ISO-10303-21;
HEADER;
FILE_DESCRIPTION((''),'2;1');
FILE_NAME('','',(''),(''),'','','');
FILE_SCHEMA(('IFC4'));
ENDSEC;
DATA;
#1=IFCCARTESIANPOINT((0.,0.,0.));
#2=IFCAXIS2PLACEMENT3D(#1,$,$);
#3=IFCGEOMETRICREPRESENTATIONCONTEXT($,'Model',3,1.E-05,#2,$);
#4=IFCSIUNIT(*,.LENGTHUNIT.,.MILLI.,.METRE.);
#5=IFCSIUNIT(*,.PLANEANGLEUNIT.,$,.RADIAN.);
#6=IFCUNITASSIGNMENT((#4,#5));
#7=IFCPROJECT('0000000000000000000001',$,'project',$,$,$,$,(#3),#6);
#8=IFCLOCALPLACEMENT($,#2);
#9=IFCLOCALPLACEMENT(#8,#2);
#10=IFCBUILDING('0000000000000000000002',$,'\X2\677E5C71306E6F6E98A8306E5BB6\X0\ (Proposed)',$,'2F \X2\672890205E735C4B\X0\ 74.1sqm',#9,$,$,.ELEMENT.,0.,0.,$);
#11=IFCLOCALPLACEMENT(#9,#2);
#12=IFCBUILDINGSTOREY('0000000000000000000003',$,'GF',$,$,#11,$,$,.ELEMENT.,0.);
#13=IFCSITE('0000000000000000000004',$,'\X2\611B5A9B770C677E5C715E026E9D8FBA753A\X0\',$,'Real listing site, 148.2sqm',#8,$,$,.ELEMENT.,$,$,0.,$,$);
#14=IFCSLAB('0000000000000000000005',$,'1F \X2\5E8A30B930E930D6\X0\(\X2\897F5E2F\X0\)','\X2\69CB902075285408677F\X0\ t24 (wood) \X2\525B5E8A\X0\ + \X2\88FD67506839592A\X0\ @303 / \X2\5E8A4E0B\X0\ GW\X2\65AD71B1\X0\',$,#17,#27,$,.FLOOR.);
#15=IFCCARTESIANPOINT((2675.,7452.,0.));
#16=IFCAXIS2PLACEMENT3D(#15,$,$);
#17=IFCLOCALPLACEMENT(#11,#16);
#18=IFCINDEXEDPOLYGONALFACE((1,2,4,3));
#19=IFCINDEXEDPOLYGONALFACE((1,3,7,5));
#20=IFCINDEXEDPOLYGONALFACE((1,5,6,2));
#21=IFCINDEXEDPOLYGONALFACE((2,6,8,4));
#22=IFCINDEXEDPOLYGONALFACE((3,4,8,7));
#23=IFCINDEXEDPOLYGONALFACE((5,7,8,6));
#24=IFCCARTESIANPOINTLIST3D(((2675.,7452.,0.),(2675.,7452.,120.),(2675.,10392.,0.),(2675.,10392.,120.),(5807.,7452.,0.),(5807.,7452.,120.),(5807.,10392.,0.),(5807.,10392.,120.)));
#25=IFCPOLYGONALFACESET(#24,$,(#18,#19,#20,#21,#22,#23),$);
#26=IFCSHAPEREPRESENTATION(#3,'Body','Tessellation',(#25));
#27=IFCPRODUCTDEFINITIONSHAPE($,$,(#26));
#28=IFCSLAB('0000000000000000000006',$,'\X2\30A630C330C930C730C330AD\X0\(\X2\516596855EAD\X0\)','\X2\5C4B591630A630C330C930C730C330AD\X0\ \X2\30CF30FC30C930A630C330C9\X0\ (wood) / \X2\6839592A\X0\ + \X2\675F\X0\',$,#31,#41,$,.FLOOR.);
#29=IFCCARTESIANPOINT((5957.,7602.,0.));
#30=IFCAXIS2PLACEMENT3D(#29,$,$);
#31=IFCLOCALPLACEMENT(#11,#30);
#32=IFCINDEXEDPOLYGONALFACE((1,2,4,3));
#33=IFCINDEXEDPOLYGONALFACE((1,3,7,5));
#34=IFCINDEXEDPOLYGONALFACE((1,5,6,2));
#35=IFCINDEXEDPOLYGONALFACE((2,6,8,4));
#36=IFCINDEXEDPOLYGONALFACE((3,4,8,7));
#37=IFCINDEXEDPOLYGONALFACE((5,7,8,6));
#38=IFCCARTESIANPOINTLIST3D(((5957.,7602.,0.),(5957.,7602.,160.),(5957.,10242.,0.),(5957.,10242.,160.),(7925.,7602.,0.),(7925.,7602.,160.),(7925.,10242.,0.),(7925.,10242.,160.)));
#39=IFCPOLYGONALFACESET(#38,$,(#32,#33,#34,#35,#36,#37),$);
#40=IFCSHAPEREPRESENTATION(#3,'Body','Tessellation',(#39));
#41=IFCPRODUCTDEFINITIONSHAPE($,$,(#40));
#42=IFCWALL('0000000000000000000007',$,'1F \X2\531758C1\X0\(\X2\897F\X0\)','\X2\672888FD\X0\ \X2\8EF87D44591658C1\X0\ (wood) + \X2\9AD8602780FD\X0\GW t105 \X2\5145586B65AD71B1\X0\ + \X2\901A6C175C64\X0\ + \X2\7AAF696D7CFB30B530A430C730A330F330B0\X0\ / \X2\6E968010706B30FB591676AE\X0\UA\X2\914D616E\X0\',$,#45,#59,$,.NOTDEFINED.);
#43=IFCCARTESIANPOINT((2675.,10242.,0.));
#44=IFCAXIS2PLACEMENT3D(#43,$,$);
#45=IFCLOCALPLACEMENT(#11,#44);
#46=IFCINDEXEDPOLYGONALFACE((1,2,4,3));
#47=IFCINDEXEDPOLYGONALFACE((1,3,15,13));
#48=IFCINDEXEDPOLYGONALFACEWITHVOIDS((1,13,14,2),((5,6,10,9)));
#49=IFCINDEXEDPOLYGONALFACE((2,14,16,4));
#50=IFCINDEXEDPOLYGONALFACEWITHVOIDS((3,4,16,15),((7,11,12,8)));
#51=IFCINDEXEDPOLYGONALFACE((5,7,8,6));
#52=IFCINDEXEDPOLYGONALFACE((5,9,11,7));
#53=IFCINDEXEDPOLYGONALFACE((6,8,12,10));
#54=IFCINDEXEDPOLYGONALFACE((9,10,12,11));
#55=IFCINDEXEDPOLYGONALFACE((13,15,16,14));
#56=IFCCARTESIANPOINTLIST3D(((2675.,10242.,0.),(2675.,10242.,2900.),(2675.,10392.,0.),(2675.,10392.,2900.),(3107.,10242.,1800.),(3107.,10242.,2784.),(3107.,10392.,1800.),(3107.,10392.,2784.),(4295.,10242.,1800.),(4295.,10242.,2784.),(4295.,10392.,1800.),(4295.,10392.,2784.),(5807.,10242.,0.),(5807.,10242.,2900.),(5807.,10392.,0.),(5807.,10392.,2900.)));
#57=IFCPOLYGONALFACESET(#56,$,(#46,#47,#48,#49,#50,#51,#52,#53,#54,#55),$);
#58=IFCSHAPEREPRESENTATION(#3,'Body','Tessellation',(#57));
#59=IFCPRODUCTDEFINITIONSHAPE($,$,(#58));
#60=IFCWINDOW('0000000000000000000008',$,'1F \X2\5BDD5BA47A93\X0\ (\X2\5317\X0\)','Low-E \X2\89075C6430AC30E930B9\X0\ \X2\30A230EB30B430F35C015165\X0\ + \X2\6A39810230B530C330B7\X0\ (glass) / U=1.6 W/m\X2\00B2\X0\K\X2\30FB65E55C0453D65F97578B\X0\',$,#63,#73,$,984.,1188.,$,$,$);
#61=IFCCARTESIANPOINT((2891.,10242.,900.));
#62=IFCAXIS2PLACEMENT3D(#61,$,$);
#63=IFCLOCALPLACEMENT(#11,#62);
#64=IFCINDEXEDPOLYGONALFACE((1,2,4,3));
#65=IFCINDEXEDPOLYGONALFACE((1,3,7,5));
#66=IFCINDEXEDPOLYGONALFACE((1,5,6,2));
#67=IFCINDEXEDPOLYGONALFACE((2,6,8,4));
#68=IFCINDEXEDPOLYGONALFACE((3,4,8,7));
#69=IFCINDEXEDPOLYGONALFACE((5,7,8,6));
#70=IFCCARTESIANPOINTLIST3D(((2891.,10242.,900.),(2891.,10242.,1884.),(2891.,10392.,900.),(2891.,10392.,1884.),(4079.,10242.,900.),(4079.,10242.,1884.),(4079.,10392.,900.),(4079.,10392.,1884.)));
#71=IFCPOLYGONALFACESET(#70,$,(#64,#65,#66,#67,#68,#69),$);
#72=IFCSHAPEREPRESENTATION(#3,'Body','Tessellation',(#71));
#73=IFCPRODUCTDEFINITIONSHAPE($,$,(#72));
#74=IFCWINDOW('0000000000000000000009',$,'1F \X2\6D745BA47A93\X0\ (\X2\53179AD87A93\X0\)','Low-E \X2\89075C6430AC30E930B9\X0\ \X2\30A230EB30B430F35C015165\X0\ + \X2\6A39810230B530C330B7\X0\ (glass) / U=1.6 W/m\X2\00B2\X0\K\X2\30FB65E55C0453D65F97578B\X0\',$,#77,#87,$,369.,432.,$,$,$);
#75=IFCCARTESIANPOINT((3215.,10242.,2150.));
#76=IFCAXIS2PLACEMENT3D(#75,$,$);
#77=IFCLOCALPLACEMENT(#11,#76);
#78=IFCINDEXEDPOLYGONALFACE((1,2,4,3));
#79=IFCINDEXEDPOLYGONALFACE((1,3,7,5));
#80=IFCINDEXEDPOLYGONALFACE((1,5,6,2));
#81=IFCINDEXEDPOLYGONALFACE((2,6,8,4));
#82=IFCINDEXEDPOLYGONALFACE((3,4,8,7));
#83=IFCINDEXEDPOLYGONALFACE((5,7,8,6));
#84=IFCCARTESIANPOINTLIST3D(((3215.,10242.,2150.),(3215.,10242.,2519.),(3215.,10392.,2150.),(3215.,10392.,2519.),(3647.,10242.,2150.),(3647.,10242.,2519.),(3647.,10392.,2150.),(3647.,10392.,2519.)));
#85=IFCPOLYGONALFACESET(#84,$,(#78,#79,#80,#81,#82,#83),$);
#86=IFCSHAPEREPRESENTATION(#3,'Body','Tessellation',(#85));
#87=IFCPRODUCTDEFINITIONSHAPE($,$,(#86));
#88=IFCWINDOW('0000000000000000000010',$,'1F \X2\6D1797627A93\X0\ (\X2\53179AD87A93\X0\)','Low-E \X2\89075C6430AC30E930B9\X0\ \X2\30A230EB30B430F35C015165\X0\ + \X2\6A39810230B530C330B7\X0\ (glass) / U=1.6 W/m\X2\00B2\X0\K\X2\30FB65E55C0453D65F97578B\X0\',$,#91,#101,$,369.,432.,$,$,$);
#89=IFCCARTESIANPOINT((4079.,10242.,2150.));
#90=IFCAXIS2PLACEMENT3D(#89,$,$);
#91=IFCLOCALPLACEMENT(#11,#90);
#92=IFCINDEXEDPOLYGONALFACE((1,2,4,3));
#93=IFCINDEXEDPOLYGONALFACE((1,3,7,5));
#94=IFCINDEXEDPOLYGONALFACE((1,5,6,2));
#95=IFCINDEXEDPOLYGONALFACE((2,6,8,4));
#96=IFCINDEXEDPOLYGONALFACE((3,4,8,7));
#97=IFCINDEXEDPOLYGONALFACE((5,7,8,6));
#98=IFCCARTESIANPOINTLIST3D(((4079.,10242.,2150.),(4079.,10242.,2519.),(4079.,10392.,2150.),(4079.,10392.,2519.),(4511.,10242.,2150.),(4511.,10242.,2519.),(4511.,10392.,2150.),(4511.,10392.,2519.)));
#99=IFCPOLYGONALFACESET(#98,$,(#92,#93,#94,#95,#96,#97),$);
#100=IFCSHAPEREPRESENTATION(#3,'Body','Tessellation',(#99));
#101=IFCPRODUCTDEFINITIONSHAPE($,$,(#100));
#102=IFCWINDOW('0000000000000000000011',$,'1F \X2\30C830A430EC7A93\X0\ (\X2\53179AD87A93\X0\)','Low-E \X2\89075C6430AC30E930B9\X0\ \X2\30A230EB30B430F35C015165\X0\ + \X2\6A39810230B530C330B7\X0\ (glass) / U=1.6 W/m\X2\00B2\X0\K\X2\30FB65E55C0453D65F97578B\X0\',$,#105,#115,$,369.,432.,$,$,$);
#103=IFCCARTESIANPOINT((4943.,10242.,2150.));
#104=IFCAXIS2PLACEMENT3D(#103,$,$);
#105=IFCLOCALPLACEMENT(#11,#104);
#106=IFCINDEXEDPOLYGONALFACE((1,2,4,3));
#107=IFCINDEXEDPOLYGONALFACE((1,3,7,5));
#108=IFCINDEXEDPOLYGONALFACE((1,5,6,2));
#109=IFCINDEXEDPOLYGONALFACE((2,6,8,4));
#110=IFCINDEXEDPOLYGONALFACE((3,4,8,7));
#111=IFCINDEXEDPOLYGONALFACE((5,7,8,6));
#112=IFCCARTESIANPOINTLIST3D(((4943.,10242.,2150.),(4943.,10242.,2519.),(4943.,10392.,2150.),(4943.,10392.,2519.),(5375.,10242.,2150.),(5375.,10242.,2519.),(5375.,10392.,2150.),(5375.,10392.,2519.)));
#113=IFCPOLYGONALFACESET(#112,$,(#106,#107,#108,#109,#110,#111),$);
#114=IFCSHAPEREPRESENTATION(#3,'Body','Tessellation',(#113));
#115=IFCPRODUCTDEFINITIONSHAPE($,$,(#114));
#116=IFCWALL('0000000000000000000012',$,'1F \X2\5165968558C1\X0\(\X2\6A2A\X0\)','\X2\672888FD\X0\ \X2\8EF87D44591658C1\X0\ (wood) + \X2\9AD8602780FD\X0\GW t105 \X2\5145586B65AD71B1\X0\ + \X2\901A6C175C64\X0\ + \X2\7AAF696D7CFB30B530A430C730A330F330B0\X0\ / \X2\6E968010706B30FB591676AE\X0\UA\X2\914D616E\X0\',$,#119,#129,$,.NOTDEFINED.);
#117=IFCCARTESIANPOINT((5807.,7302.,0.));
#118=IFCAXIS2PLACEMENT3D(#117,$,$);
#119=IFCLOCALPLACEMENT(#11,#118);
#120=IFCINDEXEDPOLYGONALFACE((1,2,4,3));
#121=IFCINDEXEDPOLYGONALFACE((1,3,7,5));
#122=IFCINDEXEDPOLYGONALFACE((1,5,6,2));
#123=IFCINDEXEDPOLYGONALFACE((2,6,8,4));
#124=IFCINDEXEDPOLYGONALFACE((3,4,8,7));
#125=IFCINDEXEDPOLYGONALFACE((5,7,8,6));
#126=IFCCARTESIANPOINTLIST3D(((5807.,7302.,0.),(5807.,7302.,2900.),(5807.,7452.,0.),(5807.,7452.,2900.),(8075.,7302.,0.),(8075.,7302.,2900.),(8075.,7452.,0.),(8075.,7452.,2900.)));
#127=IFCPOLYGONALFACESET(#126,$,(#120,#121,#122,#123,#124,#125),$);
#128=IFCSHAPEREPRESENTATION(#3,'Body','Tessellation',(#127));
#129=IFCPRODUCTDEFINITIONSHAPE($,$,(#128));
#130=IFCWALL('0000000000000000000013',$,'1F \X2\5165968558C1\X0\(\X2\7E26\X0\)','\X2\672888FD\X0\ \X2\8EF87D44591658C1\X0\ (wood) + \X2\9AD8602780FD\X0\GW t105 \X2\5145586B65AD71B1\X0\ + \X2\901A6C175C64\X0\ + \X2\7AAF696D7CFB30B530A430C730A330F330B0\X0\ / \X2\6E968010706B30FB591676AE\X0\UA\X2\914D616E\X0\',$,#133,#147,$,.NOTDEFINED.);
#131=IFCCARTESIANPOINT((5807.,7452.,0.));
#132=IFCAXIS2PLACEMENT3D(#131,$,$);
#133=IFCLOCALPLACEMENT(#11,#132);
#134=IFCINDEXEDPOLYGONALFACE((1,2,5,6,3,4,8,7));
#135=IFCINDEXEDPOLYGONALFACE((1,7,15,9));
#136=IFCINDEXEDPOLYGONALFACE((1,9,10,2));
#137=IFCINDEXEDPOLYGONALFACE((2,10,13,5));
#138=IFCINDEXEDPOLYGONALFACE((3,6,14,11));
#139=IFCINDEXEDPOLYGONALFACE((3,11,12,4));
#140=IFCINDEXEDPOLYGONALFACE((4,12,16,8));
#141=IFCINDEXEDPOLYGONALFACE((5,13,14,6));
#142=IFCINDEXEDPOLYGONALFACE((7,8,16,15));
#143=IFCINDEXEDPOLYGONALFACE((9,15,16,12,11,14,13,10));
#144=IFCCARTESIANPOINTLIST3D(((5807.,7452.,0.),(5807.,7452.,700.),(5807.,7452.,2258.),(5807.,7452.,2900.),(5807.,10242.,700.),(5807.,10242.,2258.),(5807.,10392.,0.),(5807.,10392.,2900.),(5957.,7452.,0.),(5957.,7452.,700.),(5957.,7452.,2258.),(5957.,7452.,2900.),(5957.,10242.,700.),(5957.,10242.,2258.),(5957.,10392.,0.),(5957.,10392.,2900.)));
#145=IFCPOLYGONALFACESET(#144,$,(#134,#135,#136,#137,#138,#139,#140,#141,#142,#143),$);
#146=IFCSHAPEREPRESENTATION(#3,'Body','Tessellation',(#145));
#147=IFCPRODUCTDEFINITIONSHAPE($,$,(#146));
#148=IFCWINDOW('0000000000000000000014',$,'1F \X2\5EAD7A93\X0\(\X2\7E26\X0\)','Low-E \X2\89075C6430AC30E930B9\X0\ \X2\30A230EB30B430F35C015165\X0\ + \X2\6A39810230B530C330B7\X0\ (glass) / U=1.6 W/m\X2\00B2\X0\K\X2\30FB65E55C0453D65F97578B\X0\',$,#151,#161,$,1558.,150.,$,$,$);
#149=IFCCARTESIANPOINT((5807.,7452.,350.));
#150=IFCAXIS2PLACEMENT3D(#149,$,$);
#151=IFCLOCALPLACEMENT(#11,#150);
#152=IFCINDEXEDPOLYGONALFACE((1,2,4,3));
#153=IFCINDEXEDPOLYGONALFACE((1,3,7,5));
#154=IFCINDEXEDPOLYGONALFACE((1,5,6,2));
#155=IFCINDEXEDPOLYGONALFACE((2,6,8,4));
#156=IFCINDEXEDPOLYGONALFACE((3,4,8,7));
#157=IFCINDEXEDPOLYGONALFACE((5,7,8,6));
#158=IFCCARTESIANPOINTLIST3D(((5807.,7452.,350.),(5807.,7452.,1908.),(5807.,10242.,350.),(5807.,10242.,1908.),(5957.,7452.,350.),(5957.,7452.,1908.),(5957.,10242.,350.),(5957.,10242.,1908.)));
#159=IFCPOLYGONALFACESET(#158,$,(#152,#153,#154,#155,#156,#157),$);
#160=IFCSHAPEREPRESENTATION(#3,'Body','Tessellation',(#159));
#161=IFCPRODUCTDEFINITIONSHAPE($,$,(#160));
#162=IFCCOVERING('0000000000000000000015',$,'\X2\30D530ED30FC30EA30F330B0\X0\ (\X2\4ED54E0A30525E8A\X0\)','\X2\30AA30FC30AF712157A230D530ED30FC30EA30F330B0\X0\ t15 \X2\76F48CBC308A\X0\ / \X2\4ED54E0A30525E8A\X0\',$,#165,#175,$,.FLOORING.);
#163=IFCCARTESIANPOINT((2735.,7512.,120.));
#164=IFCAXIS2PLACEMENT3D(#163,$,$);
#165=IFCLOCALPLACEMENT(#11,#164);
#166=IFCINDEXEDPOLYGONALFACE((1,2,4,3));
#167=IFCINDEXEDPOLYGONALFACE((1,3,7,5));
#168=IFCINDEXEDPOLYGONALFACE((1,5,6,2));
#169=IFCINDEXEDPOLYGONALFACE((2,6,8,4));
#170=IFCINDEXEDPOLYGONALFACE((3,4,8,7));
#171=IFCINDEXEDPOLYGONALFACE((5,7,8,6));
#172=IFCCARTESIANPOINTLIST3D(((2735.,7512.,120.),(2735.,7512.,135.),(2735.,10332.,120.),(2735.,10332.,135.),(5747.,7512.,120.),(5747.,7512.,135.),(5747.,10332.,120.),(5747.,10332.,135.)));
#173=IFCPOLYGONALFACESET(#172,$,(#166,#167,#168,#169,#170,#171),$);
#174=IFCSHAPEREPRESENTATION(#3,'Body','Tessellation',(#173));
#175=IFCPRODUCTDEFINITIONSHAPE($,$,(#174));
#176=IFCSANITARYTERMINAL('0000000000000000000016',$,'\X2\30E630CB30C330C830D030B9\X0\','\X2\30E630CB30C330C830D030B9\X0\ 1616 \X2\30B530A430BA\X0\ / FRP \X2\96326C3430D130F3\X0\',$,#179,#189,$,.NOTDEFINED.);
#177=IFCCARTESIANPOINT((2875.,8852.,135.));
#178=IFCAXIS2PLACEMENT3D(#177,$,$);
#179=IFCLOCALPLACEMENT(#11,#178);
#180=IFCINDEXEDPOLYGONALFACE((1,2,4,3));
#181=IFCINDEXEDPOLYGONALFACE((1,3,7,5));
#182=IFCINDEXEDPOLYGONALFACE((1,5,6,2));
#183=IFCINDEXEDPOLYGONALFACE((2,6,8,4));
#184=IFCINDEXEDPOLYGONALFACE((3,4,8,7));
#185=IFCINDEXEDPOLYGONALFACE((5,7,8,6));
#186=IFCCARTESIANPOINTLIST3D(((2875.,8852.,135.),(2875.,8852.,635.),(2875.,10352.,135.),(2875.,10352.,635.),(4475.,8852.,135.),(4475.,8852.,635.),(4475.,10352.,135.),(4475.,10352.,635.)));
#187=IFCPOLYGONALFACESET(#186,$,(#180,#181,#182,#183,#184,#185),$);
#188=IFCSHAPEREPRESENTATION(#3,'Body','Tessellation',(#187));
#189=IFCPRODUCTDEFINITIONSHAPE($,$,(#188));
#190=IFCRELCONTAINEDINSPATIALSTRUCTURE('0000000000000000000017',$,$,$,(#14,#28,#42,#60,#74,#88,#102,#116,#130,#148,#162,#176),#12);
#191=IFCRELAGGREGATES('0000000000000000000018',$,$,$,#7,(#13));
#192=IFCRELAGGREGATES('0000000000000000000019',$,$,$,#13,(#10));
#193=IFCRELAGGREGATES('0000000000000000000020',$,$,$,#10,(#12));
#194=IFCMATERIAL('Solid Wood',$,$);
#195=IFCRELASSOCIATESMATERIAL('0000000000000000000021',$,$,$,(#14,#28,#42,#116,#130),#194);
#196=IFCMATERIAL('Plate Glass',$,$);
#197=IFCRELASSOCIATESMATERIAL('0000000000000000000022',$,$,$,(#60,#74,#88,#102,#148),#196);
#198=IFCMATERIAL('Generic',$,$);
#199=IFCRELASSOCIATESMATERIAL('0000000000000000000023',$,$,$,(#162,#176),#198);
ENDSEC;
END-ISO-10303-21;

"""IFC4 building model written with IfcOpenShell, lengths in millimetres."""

from ifc_helpers import new_model, si_unit, frame, frame_2d, origin, place, context, project, spatial, rectangle, extrude, material, element, fill, save


model = new_model("IFC4")

# Units and contexts
model_context = context("Model", 3, precision=1e-05, world=origin())
ifc_project = project(units=[si_unit("LENGTHUNIT", "METRE", prefix="MILLI"), si_unit("PLANEANGLEUNIT", "RADIAN")], contexts=[model_context])

# Site, building, storey
site_placement = place(None, origin())
site = spatial("IfcSite", under=ifc_project, at=site_placement, Name="愛媛県松山市溝辺町", ObjectType="Real listing site, 148.2sqm", CompositionType="ELEMENT", RefElevation=0.0)
building_placement = place(site_placement, origin())
building = spatial("IfcBuilding", under=site, at=building_placement, Name="松山の潮風の家 (Proposed)", ObjectType="2F 木造平屋 74.1sqm", CompositionType="ELEMENT", ElevationOfRefHeight=0.0, ElevationOfTerrain=0.0)
storey_placement = place(building_placement, origin())
storey = spatial("IfcBuildingStorey", under=building, at=storey_placement, Name="GF", CompositionType="ELEMENT", Elevation=0.0)

# Slabs
ifc_material_1 = material(Name="Solid Wood")
slab_1_placement = place(storey_placement, frame((2675.0, 7452.0, 0.0)))
element("IfcSlab", 1, at=slab_1_placement, inside=storey, material=ifc_material_1, Name="1F 床スラブ(西帯)", Description="構造用合板 t24 (wood) 剛床 + 製材根太 @303 / 床下 GW断熱", PredefinedType="FLOOR", context=model_context, shape_type="SweptSolid", body=[
    extrude(rectangle(XDim=3132.0, YDim=2940.0, at=frame_2d((1566.0, 1470.0))), frame((2675.0, 7452.0, 0.0)), (0.0, 0.0, 1.0), 120.0),
])
slab_2_placement = place(storey_placement, frame((5957.0, 7602.0, 0.0)))
element("IfcSlab", 2, at=slab_2_placement, inside=storey, material=ifc_material_1, Name="ウッドデッキ(入隅庭)", Description="屋外ウッドデッキ ハードウッド (wood) / 根太 + 束", PredefinedType="FLOOR", context=model_context, shape_type="SweptSolid", body=[
    extrude(rectangle(XDim=1968.0, YDim=2640.0, at=frame_2d((984.0, 1320.0))), frame((5957.0, 7602.0, 0.0)), (0.0, 0.0, 1.0), 160.0),
])

# Wall, openings, windows
wall_1_placement = place(storey_placement, frame((2675.0, 10242.0, 0.0)))
wall_1 = element("IfcWall", 3, at=wall_1_placement, inside=storey, material=ifc_material_1, Name="1F 北壁(西)", Description="木製 軸組外壁 (wood) + 高性能GW t105 充填断熱 + 通気層 + 窯業系サイディング / 準耐火・外皮UA配慮", PredefinedType="NOTDEFINED", context=model_context, shape_type="SweptSolid", body=[
    extrude(rectangle(XDim=3132.0, YDim=150.0, at=frame_2d((1566.0, 75.0))), frame((2675.0, 10242.0, 0.0)), (0.0, 0.0, 1.0), 2900.0),
])
opening_1_placement = place(storey_placement, frame((2891.0, 10242.0, 900.0)))
opening_1 = element("IfcOpeningElement", 4, at=opening_1_placement, cuts=wall_1, PredefinedType="NOTDEFINED", context=model_context, shape_type="SweptSolid", body=[
    extrude(rectangle(XDim=1188.0, YDim=150.0, at=frame_2d((594.0, 75.0))), frame((2891.0, 10242.0, 900.0)), (0.0, 0.0, 1.0), 984.0),
])
opening_2_placement = place(storey_placement, frame((3215.0, 10242.0, 2150.0)))
opening_2 = element("IfcOpeningElement", 5, at=opening_2_placement, cuts=wall_1, PredefinedType="NOTDEFINED", context=model_context, shape_type="SweptSolid", body=[
    extrude(rectangle(XDim=432.0, YDim=150.0, at=frame_2d((216.0, 75.0))), frame((3215.0, 10242.0, 2150.0)), (0.0, 0.0, 1.0), 369.0),
])
opening_3_placement = place(storey_placement, frame((4079.0, 10242.0, 2150.0)))
opening_3 = element("IfcOpeningElement", 6, at=opening_3_placement, cuts=wall_1, PredefinedType="NOTDEFINED", context=model_context, shape_type="SweptSolid", body=[
    extrude(rectangle(XDim=432.0, YDim=150.0, at=frame_2d((216.0, 75.0))), frame((4079.0, 10242.0, 2150.0)), (0.0, 0.0, 1.0), 369.0),
])
opening_4_placement = place(storey_placement, frame((4943.0, 10242.0, 2150.0)))
opening_4 = element("IfcOpeningElement", 7, at=opening_4_placement, cuts=wall_1, PredefinedType="NOTDEFINED", context=model_context, shape_type="SweptSolid", body=[
    extrude(rectangle(XDim=432.0, YDim=150.0, at=frame_2d((216.0, 75.0))), frame((4943.0, 10242.0, 2150.0)), (0.0, 0.0, 1.0), 369.0),
])
ifc_material_2 = material(Name="Plate Glass")
window_1_placement = place(storey_placement, frame((2891.0, 10242.0, 900.0)))
window_1 = element("IfcWindow", 8, at=window_1_placement, inside=storey, material=ifc_material_2, Name="1F 寝室窓 (北)", Description="Low-E 複層ガラス アルゴン封入 + 樹脂サッシ (glass) / U=1.6 W/m²K・日射取得型", OverallHeight=984.0, OverallWidth=1188.0, context=model_context, shape_type="SweptSolid", body=[
    extrude(rectangle(XDim=1188.0, YDim=150.0, at=frame_2d((594.0, 75.0))), frame((2891.0, 10242.0, 900.0)), (0.0, 0.0, 1.0), 984.0),
])
fill(opening_1, window_1)
window_2_placement = place(storey_placement, frame((3215.0, 10242.0, 2150.0)))
window_2 = element("IfcWindow", 9, at=window_2_placement, inside=storey, material=ifc_material_2, Name="1F 浴室窓 (北高窓)", Description="Low-E 複層ガラス アルゴン封入 + 樹脂サッシ (glass) / U=1.6 W/m²K・日射取得型", OverallHeight=369.0, OverallWidth=432.0, context=model_context, shape_type="SweptSolid", body=[
    extrude(rectangle(XDim=432.0, YDim=150.0, at=frame_2d((216.0, 75.0))), frame((3215.0, 10242.0, 2150.0)), (0.0, 0.0, 1.0), 369.0),
])
fill(opening_2, window_2)
window_3_placement = place(storey_placement, frame((4079.0, 10242.0, 2150.0)))
window_3 = element("IfcWindow", 10, at=window_3_placement, inside=storey, material=ifc_material_2, Name="1F 洗面窓 (北高窓)", Description="Low-E 複層ガラス アルゴン封入 + 樹脂サッシ (glass) / U=1.6 W/m²K・日射取得型", OverallHeight=369.0, OverallWidth=432.0, context=model_context, shape_type="SweptSolid", body=[
    extrude(rectangle(XDim=432.0, YDim=150.0, at=frame_2d((216.0, 75.0))), frame((4079.0, 10242.0, 2150.0)), (0.0, 0.0, 1.0), 369.0),
])
fill(opening_3, window_3)
window_4_placement = place(storey_placement, frame((4943.0, 10242.0, 2150.0)))
window_4 = element("IfcWindow", 11, at=window_4_placement, inside=storey, material=ifc_material_2, Name="1F トイレ窓 (北高窓)", Description="Low-E 複層ガラス アルゴン封入 + 樹脂サッシ (glass) / U=1.6 W/m²K・日射取得型", OverallHeight=369.0, OverallWidth=432.0, context=model_context, shape_type="SweptSolid", body=[
    extrude(rectangle(XDim=432.0, YDim=150.0, at=frame_2d((216.0, 75.0))), frame((4943.0, 10242.0, 2150.0)), (0.0, 0.0, 1.0), 369.0),
])
fill(opening_4, window_4)

# Wall
wall_2_placement = place(storey_placement, frame((5807.0, 7302.0, 0.0)))
element("IfcWall", 12, at=wall_2_placement, inside=storey, material=ifc_material_1, Name="1F 入隅壁(横)", Description="木製 軸組外壁 (wood) + 高性能GW t105 充填断熱 + 通気層 + 窯業系サイディング / 準耐火・外皮UA配慮", PredefinedType="NOTDEFINED", context=model_context, shape_type="SweptSolid", body=[
    extrude(rectangle(XDim=2268.0, YDim=150.0, at=frame_2d((1134.0, 75.0))), frame((5807.0, 7302.0, 0.0)), (0.0, 0.0, 1.0), 2900.0),
])

# Wall, opening, window
wall_3_placement = place(storey_placement, frame((5807.0, 7452.0, 0.0)))
wall_3 = element("IfcWall", 13, at=wall_3_placement, inside=storey, material=ifc_material_1, Name="1F 入隅壁(縦)", Description="木製 軸組外壁 (wood) + 高性能GW t105 充填断熱 + 通気層 + 窯業系サイディング / 準耐火・外皮UA配慮", PredefinedType="NOTDEFINED", context=model_context, shape_type="SweptSolid", body=[
    extrude(rectangle(XDim=150.0, YDim=2940.0, at=frame_2d((75.0, 1470.0))), frame((5807.0, 7452.0, 0.0)), (0.0, 0.0, 1.0), 2900.0),
])
opening_5_placement = place(storey_placement, frame((5807.0, 7452.0, 350.0)))
opening_5 = element("IfcOpeningElement", 14, at=opening_5_placement, cuts=wall_3, PredefinedType="NOTDEFINED", context=model_context, shape_type="SweptSolid", body=[
    extrude(rectangle(XDim=150.0, YDim=2790.0, at=frame_2d((75.0, 1395.0))), frame((5807.0, 7452.0, 350.0)), (0.0, 0.0, 1.0), 1558.0),
])
window_5_placement = place(storey_placement, frame((5807.0, 7452.0, 350.0)))
window_5 = element("IfcWindow", 15, at=window_5_placement, inside=storey, material=ifc_material_2, Name="1F 庭窓(縦)", Description="Low-E 複層ガラス アルゴン封入 + 樹脂サッシ (glass) / U=1.6 W/m²K・日射取得型", OverallHeight=1558.0, OverallWidth=150.0, context=model_context, shape_type="SweptSolid", body=[
    extrude(rectangle(XDim=150.0, YDim=2790.0, at=frame_2d((75.0, 1395.0))), frame((5807.0, 7452.0, 350.0)), (0.0, 0.0, 1.0), 1558.0),
])
fill(opening_5, window_5)

# Covering
ifc_material_3 = material(Name="Generic")
covering_placement = place(storey_placement, frame((2735.0, 7512.0, 120.0)))
element("IfcCovering", 16, at=covering_placement, inside=storey, material=ifc_material_3, Name="フローリング (仕上げ床)", Description="オーク無垢フローリング t15 直貼り / 仕上げ床", PredefinedType="FLOORING", context=model_context, shape_type="SweptSolid", body=[
    extrude(rectangle(XDim=3012.0, YDim=2820.0, at=frame_2d((1506.0, 1410.0))), frame((2735.0, 7512.0, 120.0)), (0.0, 0.0, 1.0), 15.0),
])

# Sanitary terminal
sanitary_terminal_1_placement = place(storey_placement, frame((2875.0, 8852.0, 135.0)))
element("IfcSanitaryTerminal", 17, at=sanitary_terminal_1_placement, inside=storey, material=ifc_material_3, Name="ユニットバス", Description="ユニットバス 1616 サイズ / FRP 防水パン", PredefinedType="NOTDEFINED", context=model_context, shape_type="SweptSolid", body=[
    extrude(rectangle(XDim=1600.0, YDim=1500.0, at=frame_2d((800.0, 750.0))), frame((2875.0, 8852.0, 135.0)), (0.0, 0.0, 1.0), 500.0),
])

save(model, "model.ifc")
